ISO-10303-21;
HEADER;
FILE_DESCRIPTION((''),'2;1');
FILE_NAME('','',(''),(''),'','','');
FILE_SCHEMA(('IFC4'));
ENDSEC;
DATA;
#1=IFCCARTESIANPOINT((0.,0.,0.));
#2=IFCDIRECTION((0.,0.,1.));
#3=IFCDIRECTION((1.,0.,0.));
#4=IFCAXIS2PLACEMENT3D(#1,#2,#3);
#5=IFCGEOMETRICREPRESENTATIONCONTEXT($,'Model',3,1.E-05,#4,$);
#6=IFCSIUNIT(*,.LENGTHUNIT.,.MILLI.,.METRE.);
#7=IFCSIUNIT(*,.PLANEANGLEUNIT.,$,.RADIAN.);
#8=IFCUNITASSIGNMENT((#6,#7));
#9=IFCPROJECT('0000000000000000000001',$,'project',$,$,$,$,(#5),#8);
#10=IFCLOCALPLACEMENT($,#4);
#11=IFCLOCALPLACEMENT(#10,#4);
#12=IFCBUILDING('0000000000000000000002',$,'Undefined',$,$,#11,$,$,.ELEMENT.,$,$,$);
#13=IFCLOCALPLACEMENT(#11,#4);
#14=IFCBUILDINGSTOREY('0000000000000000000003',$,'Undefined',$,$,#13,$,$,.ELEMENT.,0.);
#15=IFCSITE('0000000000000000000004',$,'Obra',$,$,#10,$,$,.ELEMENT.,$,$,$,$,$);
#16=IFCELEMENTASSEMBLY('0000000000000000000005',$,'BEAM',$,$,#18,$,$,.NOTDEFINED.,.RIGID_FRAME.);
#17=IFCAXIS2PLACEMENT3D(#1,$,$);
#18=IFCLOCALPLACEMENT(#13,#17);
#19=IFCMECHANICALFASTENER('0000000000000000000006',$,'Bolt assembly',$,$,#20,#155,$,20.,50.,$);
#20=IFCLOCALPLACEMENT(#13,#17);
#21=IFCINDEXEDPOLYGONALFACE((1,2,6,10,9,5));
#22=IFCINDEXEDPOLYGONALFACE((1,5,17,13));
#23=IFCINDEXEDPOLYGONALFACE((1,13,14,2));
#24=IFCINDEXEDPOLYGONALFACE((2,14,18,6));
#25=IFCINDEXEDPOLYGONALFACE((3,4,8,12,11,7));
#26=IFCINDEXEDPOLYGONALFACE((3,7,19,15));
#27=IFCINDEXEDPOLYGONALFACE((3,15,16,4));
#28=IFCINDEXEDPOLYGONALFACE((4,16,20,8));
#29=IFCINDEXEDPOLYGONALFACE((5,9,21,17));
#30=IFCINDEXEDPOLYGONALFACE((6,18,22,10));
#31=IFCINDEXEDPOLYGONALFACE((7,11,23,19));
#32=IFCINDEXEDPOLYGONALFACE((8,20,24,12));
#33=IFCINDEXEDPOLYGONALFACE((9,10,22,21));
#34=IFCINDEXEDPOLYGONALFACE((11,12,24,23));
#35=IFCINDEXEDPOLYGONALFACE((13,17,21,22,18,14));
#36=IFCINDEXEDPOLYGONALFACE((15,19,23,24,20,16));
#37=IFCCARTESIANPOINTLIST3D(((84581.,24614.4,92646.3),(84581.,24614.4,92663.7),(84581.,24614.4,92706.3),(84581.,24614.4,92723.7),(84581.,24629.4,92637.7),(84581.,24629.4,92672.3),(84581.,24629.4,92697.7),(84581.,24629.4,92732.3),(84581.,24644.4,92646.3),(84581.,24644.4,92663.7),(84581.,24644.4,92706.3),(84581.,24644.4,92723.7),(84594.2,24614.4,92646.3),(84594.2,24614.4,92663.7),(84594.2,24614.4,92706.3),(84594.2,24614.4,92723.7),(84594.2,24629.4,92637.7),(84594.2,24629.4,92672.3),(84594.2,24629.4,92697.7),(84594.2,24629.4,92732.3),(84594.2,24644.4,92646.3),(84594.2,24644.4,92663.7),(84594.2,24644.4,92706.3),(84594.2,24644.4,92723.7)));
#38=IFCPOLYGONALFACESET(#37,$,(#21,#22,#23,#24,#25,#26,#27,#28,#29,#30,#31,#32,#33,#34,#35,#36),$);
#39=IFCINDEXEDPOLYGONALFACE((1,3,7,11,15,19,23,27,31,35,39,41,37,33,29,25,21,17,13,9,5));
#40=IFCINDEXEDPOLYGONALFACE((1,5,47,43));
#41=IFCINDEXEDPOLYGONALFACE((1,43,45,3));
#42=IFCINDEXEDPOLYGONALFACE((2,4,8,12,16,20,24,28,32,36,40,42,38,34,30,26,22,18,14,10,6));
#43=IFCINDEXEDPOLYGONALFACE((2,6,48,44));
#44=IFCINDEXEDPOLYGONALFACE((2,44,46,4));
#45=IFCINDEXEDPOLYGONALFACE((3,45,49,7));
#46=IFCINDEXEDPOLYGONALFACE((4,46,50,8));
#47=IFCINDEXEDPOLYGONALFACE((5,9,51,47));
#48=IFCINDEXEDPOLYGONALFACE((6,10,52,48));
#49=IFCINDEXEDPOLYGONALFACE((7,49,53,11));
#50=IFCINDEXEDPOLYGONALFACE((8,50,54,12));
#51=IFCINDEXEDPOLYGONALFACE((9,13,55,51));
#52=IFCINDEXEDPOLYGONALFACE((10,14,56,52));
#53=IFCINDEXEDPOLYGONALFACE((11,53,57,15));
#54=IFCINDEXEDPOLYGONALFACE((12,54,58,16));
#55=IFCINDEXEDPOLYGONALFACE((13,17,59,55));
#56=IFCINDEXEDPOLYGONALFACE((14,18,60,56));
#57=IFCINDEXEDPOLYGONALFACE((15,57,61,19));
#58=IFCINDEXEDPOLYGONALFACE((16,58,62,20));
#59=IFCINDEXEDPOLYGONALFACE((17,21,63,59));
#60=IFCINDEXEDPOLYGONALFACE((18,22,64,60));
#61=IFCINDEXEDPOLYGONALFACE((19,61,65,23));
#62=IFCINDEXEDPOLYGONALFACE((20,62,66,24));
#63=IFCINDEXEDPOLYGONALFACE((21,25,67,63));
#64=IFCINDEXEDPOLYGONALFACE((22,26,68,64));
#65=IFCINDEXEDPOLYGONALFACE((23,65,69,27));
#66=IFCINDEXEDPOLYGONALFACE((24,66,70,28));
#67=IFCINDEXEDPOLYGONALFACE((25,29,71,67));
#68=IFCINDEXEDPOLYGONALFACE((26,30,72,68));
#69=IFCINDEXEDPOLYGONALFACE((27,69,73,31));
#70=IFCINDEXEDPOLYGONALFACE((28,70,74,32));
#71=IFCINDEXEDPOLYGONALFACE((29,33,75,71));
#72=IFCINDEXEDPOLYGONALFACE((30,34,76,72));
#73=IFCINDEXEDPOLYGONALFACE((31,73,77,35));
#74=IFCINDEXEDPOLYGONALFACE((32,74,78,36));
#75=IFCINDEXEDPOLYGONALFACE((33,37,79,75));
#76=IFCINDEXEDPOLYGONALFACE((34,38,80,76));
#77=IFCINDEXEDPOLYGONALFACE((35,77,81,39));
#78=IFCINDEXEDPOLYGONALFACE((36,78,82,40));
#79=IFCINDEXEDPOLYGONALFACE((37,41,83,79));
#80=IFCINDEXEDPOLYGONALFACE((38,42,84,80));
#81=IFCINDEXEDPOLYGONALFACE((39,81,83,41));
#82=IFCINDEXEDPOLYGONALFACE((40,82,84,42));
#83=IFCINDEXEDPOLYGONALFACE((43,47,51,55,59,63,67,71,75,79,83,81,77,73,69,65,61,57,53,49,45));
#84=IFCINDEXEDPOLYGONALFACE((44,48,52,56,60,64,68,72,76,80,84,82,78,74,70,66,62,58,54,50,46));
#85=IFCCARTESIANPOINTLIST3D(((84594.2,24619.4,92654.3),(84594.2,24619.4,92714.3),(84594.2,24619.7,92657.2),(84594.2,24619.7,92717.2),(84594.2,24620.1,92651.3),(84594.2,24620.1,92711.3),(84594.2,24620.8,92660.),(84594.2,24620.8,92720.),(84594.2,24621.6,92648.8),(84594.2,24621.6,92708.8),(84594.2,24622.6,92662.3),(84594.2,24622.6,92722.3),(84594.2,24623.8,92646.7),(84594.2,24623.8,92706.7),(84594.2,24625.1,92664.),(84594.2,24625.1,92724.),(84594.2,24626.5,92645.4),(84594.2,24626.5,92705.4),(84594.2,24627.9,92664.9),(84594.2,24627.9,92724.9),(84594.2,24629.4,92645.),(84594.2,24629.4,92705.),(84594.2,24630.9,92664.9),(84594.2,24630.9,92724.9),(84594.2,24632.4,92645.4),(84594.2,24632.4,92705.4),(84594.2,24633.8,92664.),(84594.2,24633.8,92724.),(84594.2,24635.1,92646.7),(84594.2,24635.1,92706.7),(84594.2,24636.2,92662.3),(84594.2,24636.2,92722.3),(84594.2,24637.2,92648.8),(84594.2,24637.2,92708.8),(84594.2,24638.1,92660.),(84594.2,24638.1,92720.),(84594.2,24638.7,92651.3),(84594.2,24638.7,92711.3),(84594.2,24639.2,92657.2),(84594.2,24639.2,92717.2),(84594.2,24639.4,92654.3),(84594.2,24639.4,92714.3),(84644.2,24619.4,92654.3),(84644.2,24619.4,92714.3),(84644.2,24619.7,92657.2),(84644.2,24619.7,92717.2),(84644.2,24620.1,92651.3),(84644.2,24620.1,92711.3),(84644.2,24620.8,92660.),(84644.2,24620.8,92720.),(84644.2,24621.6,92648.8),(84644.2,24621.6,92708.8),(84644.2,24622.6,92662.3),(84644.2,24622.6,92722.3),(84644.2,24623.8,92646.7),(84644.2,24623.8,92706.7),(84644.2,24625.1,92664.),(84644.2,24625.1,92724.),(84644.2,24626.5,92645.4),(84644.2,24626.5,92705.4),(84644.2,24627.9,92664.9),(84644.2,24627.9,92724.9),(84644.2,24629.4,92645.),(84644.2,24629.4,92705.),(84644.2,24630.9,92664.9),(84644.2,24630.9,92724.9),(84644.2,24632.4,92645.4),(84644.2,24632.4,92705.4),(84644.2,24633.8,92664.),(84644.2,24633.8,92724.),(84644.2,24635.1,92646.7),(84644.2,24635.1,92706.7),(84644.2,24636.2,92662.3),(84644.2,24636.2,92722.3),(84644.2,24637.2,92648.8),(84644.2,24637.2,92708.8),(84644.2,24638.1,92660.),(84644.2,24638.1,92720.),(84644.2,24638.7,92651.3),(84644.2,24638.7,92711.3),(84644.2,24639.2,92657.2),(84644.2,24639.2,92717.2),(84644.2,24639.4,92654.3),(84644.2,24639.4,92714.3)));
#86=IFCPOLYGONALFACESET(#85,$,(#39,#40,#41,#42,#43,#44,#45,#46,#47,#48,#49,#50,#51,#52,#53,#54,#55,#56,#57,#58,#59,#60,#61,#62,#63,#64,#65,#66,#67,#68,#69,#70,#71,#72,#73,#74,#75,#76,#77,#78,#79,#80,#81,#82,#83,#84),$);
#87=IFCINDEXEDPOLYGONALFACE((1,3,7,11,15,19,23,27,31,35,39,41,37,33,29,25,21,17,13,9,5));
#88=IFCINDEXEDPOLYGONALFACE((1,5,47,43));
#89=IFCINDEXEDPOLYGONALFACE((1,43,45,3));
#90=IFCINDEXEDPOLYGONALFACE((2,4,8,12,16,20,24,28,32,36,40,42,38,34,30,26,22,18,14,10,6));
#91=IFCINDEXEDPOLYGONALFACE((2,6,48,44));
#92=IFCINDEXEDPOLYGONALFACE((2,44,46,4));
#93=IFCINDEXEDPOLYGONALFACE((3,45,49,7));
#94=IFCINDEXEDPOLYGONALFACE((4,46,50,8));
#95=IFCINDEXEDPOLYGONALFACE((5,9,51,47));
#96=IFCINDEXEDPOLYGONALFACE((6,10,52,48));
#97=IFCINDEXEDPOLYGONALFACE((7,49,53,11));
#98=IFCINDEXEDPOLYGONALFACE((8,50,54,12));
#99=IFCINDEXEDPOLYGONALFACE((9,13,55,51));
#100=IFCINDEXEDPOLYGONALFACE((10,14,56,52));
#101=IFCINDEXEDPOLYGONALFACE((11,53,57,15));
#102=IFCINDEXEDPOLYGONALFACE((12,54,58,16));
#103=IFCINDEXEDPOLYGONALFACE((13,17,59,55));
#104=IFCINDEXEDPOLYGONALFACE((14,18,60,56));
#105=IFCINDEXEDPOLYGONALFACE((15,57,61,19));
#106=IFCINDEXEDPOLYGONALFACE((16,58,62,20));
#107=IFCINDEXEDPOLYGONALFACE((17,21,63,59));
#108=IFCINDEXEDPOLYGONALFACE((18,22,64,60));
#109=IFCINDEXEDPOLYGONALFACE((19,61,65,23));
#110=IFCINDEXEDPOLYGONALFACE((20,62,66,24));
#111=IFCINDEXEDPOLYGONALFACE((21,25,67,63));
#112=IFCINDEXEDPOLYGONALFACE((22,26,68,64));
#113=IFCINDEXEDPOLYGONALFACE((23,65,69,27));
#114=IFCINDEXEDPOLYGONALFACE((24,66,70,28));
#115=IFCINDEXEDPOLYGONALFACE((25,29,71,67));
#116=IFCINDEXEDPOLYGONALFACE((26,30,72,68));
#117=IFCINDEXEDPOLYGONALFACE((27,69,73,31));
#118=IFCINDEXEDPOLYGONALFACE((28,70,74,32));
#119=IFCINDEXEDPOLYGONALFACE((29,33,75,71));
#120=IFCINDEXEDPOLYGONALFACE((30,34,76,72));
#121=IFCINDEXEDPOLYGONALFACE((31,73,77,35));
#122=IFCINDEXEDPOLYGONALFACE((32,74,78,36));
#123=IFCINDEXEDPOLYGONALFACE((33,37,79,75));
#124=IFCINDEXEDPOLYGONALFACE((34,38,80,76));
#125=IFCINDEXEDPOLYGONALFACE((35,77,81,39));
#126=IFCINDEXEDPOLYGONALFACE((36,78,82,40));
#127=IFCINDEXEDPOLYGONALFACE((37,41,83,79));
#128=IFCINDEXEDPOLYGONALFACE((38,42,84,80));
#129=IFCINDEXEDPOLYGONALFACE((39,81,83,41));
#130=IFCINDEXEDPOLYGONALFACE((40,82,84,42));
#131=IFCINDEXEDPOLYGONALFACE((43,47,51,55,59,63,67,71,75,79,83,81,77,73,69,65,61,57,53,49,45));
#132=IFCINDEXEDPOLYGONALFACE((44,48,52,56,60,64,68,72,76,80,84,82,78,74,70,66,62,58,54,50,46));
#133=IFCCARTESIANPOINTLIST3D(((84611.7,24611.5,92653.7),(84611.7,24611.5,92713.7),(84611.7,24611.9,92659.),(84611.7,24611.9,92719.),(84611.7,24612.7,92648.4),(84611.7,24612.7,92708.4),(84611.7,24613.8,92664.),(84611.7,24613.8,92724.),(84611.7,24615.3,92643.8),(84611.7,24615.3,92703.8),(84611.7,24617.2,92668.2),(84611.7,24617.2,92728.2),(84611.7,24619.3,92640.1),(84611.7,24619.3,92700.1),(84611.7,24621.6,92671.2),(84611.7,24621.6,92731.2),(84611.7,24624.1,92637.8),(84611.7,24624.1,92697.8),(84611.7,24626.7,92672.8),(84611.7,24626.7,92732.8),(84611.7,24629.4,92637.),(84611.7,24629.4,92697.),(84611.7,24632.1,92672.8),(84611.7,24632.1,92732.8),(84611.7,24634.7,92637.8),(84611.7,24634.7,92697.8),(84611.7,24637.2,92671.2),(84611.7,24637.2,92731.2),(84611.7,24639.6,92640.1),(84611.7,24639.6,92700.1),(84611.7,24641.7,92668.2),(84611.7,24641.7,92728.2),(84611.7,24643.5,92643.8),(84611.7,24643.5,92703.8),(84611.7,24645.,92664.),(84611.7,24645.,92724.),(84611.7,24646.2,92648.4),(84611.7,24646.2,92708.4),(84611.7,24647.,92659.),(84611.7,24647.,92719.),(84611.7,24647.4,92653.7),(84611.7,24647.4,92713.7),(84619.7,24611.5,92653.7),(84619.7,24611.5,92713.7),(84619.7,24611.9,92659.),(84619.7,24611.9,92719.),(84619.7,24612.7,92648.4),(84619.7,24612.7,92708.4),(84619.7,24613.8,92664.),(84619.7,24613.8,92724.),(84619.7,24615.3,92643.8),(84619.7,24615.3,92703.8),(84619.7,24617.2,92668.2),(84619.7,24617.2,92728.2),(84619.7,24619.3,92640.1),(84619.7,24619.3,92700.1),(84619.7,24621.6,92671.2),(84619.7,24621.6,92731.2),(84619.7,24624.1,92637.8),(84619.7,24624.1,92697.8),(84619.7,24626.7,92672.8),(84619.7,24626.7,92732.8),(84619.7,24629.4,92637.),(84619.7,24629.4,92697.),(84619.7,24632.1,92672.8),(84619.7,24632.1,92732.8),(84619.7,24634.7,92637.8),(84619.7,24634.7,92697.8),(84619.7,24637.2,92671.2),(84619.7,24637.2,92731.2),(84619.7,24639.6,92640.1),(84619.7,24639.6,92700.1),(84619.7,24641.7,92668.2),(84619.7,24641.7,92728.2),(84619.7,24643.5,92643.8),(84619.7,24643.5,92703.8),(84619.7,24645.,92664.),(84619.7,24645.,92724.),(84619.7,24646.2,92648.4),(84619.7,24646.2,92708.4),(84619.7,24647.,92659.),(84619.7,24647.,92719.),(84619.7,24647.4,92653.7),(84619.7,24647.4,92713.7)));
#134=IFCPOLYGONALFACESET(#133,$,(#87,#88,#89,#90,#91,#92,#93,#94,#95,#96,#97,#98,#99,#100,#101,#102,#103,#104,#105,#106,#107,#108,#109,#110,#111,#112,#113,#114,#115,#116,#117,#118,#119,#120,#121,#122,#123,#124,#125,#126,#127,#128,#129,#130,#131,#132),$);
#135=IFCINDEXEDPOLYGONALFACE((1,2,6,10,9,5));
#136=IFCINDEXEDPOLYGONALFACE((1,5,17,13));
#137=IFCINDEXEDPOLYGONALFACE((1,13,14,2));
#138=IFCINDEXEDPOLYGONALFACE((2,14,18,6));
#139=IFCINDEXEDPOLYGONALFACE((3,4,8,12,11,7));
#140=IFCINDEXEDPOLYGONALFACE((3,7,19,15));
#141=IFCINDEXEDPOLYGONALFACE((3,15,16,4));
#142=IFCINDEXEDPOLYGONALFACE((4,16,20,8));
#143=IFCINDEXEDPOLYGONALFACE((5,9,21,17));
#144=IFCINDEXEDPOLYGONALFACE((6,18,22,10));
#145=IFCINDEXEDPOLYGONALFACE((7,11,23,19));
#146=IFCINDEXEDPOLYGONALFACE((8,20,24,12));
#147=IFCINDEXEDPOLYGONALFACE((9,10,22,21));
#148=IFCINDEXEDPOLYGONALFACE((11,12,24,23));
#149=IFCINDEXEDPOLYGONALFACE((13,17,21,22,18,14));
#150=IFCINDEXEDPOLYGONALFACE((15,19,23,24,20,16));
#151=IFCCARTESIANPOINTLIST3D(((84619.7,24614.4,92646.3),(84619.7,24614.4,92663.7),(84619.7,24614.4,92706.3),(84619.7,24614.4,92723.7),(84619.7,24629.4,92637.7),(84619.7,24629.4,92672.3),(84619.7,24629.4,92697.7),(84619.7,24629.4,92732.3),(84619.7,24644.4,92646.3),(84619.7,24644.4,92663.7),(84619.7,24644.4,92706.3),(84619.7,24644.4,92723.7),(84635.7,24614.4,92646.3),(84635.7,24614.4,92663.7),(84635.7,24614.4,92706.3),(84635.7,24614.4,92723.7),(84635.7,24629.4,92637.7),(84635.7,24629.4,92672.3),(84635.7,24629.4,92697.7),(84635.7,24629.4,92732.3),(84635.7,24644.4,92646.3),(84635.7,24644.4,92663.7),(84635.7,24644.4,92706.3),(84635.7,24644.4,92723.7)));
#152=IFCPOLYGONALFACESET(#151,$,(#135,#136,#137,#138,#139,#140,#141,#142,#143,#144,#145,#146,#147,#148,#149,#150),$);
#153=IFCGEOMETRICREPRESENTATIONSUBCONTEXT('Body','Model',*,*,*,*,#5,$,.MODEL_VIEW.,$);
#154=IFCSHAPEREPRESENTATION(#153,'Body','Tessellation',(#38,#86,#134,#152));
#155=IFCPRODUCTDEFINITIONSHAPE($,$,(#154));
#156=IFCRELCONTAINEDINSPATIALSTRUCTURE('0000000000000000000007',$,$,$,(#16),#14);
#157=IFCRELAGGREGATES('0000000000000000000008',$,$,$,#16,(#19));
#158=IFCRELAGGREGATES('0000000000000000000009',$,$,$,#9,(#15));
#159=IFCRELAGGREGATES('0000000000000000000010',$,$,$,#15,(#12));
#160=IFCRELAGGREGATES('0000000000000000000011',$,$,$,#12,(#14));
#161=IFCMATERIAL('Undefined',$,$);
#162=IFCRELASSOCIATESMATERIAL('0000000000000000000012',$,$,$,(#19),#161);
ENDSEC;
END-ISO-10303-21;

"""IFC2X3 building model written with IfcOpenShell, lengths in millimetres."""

from ifc_helpers import new_model, si_unit, frame, origin_with_axes, origin_2d_with_axis, place, context, subcontext, project, spatial, polyline, circle, outline, extrude, source, transform, mapped, material, element, aggregate, save


model = new_model("IFC2X3")

# Units and contexts
model_context = context("Model", 3, precision=1e-05, world=origin_with_axes())
body_context = subcontext(model_context, "Body", "Model", "MODEL_VIEW")
ifc_project = project(units=[si_unit("LENGTHUNIT", "METRE", prefix="MILLI"), si_unit("PLANEANGLEUNIT", "RADIAN")], contexts=[model_context])

# Site, building, storey
site_placement = place(None, origin_with_axes())
site = spatial("IfcSite", under=ifc_project, at=site_placement, Name="Obra", CompositionType="ELEMENT")
building_placement = place(site_placement, origin_with_axes())
building = spatial("IfcBuilding", under=site, at=building_placement, Name="Undefined", CompositionType="ELEMENT")
storey_placement = place(building_placement, origin_with_axes())
storey = spatial("IfcBuildingStorey", under=building, at=storey_placement, Name="Undefined", CompositionType="ELEMENT", Elevation=0.0)

# Shared definitions
ifc_material_1 = material(Name="Undefined")

# Element assembly, mechanical fastener
assembly_1_placement = place(storey_placement, origin_with_axes())
assembly_1 = element("IfcElementAssembly", 1, at=assembly_1_placement, inside=storey, Name="BEAM", AssemblyPlace="NOTDEFINED", PredefinedType="RIGID_FRAME")
shared_shape_1 = source(origin_with_axes(), body_context, "Body", "SweptSolid", [
    extrude(outline(polyline([(17.3, 0.0), (8.7, 15.0), (-8.7, 15.0), (-17.3, 0.0), (-8.7, -15.0), (8.7, -15.0), (17.3, 0.0)])), frame((0.0, -27.0, 0.0), z_axis=(0.0, 1.0, 0.0), x_axis=(1.0, 0.0, 0.0)), (0.0, 0.0, 1.0), 13.2),
    extrude(circle(Radius=10.0, at=origin_2d_with_axis()), frame((0.0, -13.8, 0.0), z_axis=(0.0, 1.0, 0.0), x_axis=(1.0, 0.0, 0.0)), (0.0, 0.0, 1.0), 50.0),
    extrude(circle(Radius=18.0, at=origin_2d_with_axis()), frame((0.0, 3.7, 0.0), z_axis=(0.0, 1.0, 0.0), x_axis=(1.0, 0.0, 0.0)), (0.0, 0.0, 1.0), 8.0),
    extrude(outline(polyline([(17.3, 0.0), (8.7, 15.0), (-8.7, 15.0), (-17.3, 0.0), (-8.7, -15.0), (8.7, -15.0), (17.3, 0.0)])), frame((0.0, 11.7, 0.0), z_axis=(0.0, 1.0, 0.0), x_axis=(1.0, 0.0, 0.0)), (0.0, 0.0, 1.0), 16.0),
])
mechanical_fastener_1_placement = place(assembly_1_placement, frame((84607.9, 24669.4, 92850.0), z_axis=(0.000002, -1.0, 0.0), x_axis=(0.0, 0.0, -1.0)))
mechanical_fastener_1 = element("IfcMechanicalFastener", 2, at=mechanical_fastener_1_placement, material=ifc_material_1, Name="Bolt assembly", NominalDiameter=20.0, NominalLength=50.0, context=body_context, shape_type="MappedRepresentation", body=[
    mapped(shared_shape_1, transform((135.0, 0.0, 40.0))),
    mapped(shared_shape_1, transform((195.0, 0.0, 40.0))),
])
aggregate(assembly_1, [mechanical_fastener_1])

save(model, "model.ifc")
